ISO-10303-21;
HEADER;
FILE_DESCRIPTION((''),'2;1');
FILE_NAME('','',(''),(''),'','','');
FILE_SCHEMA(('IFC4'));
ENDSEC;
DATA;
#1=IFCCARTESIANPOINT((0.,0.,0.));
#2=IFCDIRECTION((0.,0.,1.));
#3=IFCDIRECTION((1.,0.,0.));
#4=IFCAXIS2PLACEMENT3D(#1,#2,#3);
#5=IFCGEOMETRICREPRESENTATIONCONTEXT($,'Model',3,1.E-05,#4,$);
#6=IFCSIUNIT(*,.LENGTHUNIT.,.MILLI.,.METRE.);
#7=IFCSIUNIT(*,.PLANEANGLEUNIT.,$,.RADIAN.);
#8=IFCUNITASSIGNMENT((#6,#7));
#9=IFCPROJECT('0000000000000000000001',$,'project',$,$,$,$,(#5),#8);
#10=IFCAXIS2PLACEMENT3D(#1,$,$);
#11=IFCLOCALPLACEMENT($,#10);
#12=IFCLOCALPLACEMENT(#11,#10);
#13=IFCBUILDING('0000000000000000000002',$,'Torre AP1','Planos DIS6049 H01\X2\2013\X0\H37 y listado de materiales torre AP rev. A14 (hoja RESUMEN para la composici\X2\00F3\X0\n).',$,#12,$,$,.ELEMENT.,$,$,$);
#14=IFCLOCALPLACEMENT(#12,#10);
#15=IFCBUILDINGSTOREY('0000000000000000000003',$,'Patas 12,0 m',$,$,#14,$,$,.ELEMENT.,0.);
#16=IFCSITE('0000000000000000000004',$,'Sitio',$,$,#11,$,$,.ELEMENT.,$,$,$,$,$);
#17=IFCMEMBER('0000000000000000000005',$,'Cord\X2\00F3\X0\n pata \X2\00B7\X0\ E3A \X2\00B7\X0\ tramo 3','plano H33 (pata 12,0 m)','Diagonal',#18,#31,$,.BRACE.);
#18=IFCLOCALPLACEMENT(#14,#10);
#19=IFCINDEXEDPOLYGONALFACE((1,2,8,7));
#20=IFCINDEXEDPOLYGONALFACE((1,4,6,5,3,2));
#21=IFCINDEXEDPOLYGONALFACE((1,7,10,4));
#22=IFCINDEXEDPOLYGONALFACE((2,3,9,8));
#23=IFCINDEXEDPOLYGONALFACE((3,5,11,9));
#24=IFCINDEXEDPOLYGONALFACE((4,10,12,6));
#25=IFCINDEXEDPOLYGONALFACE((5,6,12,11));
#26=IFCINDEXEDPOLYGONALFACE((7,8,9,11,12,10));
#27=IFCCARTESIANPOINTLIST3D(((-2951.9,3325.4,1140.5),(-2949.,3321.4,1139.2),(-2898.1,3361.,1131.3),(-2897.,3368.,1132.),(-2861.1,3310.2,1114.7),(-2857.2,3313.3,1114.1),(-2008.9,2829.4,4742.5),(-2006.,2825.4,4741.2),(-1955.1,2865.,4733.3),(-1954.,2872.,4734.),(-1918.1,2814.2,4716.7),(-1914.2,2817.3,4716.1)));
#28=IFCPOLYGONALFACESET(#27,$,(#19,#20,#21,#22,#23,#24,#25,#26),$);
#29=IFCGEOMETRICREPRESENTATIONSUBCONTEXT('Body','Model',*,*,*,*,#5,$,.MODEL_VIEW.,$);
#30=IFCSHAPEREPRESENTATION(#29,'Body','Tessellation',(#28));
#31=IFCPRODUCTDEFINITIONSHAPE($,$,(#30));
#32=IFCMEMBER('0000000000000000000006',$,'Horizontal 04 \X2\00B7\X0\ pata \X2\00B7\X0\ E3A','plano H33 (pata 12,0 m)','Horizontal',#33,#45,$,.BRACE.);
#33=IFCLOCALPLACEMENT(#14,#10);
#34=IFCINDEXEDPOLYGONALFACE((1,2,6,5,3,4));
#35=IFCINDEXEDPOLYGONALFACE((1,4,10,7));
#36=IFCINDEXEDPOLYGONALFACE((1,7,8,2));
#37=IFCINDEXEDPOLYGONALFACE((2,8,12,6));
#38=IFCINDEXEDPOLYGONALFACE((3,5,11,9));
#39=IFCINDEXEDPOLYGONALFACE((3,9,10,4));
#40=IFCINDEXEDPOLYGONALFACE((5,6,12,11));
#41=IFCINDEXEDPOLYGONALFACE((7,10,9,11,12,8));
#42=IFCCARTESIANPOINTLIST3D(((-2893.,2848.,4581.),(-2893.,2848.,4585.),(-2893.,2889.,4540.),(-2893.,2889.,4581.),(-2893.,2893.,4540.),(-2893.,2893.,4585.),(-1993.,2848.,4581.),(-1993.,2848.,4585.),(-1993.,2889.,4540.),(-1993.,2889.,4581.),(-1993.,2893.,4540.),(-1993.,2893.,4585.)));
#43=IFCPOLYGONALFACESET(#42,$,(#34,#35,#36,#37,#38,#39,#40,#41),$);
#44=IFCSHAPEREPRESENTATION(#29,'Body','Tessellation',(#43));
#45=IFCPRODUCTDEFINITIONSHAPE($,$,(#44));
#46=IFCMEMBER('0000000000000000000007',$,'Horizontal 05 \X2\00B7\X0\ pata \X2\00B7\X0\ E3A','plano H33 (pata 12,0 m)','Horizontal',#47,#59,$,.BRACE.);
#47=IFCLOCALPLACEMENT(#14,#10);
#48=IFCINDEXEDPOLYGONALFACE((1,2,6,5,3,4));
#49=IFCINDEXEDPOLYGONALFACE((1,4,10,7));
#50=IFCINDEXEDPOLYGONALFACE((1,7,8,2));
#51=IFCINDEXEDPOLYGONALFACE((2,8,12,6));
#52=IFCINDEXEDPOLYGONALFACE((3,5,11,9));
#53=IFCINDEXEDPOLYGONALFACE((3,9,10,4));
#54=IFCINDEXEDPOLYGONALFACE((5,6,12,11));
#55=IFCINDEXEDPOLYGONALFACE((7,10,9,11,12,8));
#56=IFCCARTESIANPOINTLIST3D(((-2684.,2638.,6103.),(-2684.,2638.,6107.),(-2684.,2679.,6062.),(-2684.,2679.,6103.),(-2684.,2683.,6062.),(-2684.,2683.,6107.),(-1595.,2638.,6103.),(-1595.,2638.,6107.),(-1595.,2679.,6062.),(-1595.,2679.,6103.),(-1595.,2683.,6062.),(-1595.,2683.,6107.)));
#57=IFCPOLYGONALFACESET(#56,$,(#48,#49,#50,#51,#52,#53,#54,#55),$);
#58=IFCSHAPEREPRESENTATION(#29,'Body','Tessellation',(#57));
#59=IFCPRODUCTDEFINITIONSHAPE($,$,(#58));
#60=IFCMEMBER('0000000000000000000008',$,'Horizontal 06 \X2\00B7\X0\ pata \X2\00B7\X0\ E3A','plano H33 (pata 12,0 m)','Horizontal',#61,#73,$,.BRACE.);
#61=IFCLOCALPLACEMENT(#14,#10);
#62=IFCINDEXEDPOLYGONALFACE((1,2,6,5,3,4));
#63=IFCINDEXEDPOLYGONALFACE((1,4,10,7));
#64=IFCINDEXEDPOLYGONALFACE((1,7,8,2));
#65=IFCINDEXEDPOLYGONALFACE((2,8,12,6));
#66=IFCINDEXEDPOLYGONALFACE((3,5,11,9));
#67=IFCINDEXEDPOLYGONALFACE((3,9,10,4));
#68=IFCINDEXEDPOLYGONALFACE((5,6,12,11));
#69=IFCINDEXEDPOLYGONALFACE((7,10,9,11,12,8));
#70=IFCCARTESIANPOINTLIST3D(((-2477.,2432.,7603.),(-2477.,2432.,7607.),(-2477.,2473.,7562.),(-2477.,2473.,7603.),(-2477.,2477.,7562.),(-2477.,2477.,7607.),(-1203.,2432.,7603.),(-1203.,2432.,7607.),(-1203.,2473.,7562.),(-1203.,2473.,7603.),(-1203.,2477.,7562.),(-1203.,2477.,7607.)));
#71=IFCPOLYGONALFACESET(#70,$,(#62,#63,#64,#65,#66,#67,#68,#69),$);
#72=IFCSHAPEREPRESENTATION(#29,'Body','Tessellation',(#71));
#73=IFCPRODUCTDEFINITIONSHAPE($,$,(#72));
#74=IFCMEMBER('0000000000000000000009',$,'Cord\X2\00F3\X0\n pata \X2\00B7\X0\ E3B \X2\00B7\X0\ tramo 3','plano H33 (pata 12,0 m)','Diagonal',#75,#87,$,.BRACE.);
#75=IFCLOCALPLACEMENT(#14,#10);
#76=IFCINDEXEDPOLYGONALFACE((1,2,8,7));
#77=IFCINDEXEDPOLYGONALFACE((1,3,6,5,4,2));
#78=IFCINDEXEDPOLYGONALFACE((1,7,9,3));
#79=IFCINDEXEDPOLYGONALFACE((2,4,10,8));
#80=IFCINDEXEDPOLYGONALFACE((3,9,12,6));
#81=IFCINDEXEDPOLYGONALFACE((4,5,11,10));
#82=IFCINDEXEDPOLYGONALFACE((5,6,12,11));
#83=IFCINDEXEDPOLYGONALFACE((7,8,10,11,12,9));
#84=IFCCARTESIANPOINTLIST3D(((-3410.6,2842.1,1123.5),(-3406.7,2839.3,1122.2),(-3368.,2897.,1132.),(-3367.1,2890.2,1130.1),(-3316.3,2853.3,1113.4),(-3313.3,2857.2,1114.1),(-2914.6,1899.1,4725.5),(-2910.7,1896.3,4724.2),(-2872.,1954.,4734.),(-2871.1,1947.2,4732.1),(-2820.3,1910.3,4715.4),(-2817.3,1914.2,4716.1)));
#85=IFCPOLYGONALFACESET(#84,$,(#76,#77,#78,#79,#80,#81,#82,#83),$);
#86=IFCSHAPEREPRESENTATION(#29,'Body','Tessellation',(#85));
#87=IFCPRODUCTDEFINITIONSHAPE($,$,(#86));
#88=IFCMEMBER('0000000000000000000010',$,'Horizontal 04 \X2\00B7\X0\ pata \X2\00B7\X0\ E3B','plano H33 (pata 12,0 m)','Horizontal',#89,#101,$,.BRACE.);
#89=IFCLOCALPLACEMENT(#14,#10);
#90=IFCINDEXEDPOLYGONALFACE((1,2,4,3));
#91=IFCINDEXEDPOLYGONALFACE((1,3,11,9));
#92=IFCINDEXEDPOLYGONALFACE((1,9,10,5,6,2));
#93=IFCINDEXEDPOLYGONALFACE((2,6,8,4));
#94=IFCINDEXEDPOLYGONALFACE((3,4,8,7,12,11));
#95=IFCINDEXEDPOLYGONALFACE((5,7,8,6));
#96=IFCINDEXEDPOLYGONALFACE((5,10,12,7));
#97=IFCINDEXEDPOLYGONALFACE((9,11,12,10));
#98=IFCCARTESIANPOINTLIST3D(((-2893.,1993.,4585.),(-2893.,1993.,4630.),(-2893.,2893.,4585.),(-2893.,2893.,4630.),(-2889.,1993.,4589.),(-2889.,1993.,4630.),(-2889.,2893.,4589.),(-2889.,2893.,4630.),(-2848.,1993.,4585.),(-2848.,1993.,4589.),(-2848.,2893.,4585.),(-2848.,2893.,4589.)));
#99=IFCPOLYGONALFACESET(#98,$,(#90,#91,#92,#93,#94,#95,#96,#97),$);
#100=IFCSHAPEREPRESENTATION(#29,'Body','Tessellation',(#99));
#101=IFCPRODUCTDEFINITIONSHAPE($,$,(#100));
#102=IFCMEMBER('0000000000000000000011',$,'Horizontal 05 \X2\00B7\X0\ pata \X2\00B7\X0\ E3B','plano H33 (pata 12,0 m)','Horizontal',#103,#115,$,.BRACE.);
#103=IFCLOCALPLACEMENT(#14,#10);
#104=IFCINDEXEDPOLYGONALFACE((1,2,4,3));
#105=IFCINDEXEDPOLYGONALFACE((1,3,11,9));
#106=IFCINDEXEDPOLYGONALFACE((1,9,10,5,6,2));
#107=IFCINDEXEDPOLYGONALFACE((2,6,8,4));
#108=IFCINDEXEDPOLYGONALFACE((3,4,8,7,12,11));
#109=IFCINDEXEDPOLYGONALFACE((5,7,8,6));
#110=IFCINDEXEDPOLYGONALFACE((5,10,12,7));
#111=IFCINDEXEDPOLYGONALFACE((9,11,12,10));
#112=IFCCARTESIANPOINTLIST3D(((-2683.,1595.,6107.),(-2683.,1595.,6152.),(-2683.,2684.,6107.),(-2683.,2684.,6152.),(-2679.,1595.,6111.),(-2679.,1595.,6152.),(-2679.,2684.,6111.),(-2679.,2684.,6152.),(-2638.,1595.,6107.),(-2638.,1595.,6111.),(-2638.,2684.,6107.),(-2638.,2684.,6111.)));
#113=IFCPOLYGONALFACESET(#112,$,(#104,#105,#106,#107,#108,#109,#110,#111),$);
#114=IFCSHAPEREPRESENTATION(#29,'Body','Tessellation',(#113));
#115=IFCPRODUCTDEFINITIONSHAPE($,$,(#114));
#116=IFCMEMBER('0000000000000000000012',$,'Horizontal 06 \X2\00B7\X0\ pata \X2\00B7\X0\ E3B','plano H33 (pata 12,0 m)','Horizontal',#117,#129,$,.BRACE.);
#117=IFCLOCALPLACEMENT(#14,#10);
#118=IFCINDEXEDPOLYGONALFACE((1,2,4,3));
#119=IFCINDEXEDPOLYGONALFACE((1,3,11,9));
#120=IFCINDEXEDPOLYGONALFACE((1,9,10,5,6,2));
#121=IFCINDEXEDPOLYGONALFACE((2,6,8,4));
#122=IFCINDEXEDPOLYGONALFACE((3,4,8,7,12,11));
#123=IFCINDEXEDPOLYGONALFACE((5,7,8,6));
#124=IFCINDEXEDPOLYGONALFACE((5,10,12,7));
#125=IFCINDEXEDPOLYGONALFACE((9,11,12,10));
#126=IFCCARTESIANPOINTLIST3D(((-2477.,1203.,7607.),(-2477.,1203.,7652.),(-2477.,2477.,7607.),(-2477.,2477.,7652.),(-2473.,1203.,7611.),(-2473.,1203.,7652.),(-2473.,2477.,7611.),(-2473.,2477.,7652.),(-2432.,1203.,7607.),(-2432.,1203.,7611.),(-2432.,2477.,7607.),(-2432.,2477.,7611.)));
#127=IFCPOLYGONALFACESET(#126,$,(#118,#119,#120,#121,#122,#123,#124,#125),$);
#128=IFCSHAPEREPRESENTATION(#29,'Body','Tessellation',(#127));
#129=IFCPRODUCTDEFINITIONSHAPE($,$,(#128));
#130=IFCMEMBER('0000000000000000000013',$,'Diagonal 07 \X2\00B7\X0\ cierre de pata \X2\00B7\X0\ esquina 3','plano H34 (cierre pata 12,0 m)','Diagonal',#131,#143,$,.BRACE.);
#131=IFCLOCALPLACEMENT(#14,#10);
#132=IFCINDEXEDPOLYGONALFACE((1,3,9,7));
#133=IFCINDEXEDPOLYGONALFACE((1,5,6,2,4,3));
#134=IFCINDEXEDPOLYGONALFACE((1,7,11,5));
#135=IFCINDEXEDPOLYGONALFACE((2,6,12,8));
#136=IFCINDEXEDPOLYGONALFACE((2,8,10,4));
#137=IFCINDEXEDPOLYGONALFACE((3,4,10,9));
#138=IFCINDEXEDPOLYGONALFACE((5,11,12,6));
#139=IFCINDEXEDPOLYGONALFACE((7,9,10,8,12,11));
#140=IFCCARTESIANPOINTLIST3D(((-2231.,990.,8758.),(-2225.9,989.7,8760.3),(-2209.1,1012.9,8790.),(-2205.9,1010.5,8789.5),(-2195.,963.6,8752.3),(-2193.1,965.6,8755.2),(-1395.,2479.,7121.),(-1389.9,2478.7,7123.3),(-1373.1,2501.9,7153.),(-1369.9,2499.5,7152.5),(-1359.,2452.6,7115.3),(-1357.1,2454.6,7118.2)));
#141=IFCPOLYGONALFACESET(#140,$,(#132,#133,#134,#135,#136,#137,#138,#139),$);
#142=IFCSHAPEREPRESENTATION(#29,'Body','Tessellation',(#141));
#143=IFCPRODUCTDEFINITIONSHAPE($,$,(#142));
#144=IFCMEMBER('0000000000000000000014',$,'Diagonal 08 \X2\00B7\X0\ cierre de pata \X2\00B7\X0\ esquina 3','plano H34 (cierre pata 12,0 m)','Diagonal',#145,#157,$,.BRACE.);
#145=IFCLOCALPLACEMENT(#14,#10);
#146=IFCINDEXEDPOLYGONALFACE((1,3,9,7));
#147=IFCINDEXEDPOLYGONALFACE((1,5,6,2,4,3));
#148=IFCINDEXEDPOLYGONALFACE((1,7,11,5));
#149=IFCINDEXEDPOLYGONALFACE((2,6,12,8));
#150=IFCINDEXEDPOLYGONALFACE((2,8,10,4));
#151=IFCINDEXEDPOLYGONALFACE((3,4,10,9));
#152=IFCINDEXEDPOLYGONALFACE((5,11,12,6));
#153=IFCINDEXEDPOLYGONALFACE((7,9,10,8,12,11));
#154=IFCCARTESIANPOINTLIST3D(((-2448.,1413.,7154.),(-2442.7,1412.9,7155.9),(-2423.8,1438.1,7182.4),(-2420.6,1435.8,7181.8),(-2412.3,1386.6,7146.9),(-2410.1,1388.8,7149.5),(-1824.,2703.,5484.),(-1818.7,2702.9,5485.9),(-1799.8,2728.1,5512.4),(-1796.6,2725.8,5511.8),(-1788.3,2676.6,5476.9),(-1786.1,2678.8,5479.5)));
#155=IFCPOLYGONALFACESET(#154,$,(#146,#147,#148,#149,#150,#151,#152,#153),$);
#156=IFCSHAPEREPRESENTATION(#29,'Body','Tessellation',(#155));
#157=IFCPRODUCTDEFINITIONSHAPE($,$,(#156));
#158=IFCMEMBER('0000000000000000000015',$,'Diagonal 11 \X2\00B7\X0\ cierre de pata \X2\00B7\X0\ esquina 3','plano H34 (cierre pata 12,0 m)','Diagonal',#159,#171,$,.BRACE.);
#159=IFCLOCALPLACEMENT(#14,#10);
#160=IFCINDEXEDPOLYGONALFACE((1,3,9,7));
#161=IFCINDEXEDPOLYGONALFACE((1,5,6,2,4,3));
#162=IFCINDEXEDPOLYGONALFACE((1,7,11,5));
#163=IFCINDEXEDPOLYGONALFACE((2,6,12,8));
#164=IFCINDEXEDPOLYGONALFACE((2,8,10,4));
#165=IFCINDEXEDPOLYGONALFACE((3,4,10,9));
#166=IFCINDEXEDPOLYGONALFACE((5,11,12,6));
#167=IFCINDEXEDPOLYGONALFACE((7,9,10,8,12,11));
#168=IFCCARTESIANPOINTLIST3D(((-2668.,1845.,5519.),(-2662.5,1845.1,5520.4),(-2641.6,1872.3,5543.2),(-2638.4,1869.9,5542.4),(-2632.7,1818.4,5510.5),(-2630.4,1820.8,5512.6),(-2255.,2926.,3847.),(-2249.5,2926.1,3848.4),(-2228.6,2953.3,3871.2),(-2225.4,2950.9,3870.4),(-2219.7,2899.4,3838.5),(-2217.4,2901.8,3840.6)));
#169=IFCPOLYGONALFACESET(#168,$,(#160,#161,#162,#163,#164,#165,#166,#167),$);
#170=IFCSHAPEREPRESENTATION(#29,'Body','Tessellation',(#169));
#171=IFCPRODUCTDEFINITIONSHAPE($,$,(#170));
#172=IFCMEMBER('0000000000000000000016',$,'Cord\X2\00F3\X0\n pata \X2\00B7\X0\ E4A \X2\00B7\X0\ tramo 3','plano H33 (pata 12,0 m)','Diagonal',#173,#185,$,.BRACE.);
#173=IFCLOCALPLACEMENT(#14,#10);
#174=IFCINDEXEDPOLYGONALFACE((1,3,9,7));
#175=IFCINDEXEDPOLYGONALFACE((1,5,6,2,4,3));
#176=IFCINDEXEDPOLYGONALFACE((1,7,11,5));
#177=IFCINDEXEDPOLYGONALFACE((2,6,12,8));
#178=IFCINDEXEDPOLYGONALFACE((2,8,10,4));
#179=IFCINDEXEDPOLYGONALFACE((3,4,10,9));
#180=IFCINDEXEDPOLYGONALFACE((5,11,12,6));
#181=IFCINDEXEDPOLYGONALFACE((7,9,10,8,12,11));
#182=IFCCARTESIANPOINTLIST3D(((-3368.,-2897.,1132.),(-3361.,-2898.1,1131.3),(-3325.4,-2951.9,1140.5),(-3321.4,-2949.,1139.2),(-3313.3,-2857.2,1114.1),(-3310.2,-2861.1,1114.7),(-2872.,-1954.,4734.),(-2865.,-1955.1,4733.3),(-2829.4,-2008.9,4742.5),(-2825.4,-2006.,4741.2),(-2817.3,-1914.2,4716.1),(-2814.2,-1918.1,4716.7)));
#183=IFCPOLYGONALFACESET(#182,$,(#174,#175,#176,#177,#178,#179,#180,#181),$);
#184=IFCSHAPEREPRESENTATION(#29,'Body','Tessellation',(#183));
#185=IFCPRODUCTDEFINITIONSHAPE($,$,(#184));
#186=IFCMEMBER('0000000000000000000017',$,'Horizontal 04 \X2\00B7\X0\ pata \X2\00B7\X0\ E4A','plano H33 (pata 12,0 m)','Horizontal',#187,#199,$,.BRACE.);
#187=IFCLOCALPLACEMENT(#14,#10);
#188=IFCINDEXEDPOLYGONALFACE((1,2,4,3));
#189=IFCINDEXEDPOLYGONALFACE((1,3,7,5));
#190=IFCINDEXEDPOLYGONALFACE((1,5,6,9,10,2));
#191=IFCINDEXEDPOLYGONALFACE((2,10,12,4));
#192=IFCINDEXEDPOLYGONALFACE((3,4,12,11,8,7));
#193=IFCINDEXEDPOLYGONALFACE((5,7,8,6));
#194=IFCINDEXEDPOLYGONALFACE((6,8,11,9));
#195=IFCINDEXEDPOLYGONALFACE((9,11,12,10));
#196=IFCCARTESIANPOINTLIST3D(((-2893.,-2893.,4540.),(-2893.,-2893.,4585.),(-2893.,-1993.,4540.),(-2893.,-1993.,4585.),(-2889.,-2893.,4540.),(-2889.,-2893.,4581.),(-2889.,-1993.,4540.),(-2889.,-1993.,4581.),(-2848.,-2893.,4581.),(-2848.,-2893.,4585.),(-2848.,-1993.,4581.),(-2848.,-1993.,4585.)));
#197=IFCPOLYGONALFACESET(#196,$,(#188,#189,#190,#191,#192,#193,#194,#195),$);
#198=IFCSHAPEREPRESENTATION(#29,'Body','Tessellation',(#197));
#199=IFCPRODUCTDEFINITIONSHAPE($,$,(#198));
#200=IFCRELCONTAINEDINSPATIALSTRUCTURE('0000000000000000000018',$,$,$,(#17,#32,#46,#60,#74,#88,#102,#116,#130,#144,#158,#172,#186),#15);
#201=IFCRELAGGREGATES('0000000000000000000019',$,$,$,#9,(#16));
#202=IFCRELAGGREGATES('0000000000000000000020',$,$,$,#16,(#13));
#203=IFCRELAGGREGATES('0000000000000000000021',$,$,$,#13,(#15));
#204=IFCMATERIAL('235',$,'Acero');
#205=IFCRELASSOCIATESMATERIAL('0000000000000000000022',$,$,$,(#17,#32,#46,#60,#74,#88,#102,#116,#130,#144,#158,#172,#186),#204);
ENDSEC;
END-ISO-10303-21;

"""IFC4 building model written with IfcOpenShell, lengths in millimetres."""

from ifc_helpers import new_model, si_unit, frame, frame_2d, origin, origin_with_axes, place, context, subcontext, project, spatial, l_section, extrude, material, element, save


model = new_model("IFC4")

# Units and contexts
model_context = context("Model", 3, precision=1e-05, world=origin_with_axes())
body_context = subcontext(model_context, "Body", "Model", "MODEL_VIEW")
ifc_project = project(units=[si_unit("LENGTHUNIT", "METRE", prefix="MILLI"), si_unit("PLANEANGLEUNIT", "RADIAN")], contexts=[model_context])

# Site, building, storey
site_placement = place(None, origin())
site = spatial("IfcSite", under=ifc_project, at=site_placement, Name="Sitio", CompositionType="ELEMENT")
building_placement = place(site_placement, origin())
building = spatial("IfcBuilding", under=site, at=building_placement, Name="Torre AP1", Description="Planos DIS6049 H01–H37 y listado de materiales torre AP rev. A14 (hoja RESUMEN para la composición).", CompositionType="ELEMENT")
storey_placement = place(building_placement, origin())
storey = spatial("IfcBuildingStorey", under=building, at=storey_placement, Name="Patas 12,0 m", CompositionType="ELEMENT", Elevation=0.0)

# Members
ifc_material = material(Name="235", Category="Acero")
member_1_placement = place(storey_placement, frame((-1954.0, 2872.0, 4734.0), z_axis=(-0.251046, 0.132045, -0.958926), x_axis=(0.56819, -0.781925, -0.256424)))
element("IfcMember", 1, at=member_1_placement, inside=storey, material=ifc_material, Name="Cordón pata · E3A · tramo 3", Description="plano H33 (pata 12,0 m)", ObjectType="Diagonal", PredefinedType="BRACE", context=body_context, shape_type="SweptSolid", body=[
    extrude(l_section(Depth=70.0, Width=70.0, Thickness=5.0, at=frame_2d((35.0, 35.0))), None, (0.0, 0.0, 1.0), 3756.3),
])
member_2_placement = place(storey_placement, frame((-2893.0, 2893.0, 4585.0), z_axis=(1.0, 0.0, 0.0), x_axis=(0.0, -1.0, 0.0)))
element("IfcMember", 2, at=member_2_placement, inside=storey, material=ifc_material, Name="Horizontal 04 · pata · E3A", Description="plano H33 (pata 12,0 m)", ObjectType="Horizontal", PredefinedType="BRACE", context=body_context, shape_type="SweptSolid", body=[
    extrude(l_section(Depth=45.0, Width=45.0, Thickness=4.0, at=frame_2d((22.5, 22.5))), None, (0.0, 0.0, 1.0), 900.0),
])
member_3_placement = place(storey_placement, frame((-2684.0, 2683.0, 6107.0), z_axis=(1.0, 0.0, 0.0), x_axis=(0.0, -1.0, 0.0)))
element("IfcMember", 3, at=member_3_placement, inside=storey, material=ifc_material, Name="Horizontal 05 · pata · E3A", Description="plano H33 (pata 12,0 m)", ObjectType="Horizontal", PredefinedType="BRACE", context=body_context, shape_type="SweptSolid", body=[
    extrude(l_section(Depth=45.0, Width=45.0, Thickness=4.0, at=frame_2d((22.5, 22.5))), None, (0.0, 0.0, 1.0), 1089.0),
])
member_4_placement = place(storey_placement, frame((-2477.0, 2477.0, 7607.0), z_axis=(1.0, 0.0, 0.0), x_axis=(0.0, -1.0, 0.0)))
element("IfcMember", 4, at=member_4_placement, inside=storey, material=ifc_material, Name="Horizontal 06 · pata · E3A", Description="plano H33 (pata 12,0 m)", ObjectType="Horizontal", PredefinedType="BRACE", context=body_context, shape_type="SweptSolid", body=[
    extrude(l_section(Depth=45.0, Width=45.0, Thickness=4.0, at=frame_2d((22.5, 22.5))), None, (0.0, 0.0, 1.0), 1274.0),
])
member_5_placement = place(storey_placement, frame((-2872.0, 1954.0, 4734.0), z_axis=(-0.132045, 0.251046, -0.958926), x_axis=(0.781925, -0.56819, -0.256424)))
element("IfcMember", 5, at=member_5_placement, inside=storey, material=ifc_material, Name="Cordón pata · E3B · tramo 3", Description="plano H33 (pata 12,0 m)", ObjectType="Diagonal", PredefinedType="BRACE", context=body_context, shape_type="SweptSolid", body=[
    extrude(l_section(Depth=70.0, Width=70.0, Thickness=5.0, at=frame_2d((35.0, 35.0))), None, (0.0, 0.0, 1.0), 3756.3),
])
member_6_placement = place(storey_placement, frame((-2893.0, 2893.0, 4585.0), z_axis=(0.0, -1.0, 0.0), x_axis=(1.0, 0.0, 0.0)))
element("IfcMember", 6, at=member_6_placement, inside=storey, material=ifc_material, Name="Horizontal 04 · pata · E3B", Description="plano H33 (pata 12,0 m)", ObjectType="Horizontal", PredefinedType="BRACE", context=body_context, shape_type="SweptSolid", body=[
    extrude(l_section(Depth=45.0, Width=45.0, Thickness=4.0, at=frame_2d((22.5, 22.5))), None, (0.0, 0.0, 1.0), 900.0),
])
member_7_placement = place(storey_placement, frame((-2683.0, 2684.0, 6107.0), z_axis=(0.0, -1.0, 0.0), x_axis=(1.0, 0.0, 0.0)))
element("IfcMember", 7, at=member_7_placement, inside=storey, material=ifc_material, Name="Horizontal 05 · pata · E3B", Description="plano H33 (pata 12,0 m)", ObjectType="Horizontal", PredefinedType="BRACE", context=body_context, shape_type="SweptSolid", body=[
    extrude(l_section(Depth=45.0, Width=45.0, Thickness=4.0, at=frame_2d((22.5, 22.5))), None, (0.0, 0.0, 1.0), 1089.0),
])
member_8_placement = place(storey_placement, frame((-2477.0, 2477.0, 7607.0), z_axis=(0.0, -1.0, 0.0), x_axis=(1.0, 0.0, 0.0)))
element("IfcMember", 8, at=member_8_placement, inside=storey, material=ifc_material, Name="Horizontal 06 · pata · E3B", Description="plano H33 (pata 12,0 m)", ObjectType="Horizontal", PredefinedType="BRACE", context=body_context, shape_type="SweptSolid", body=[
    extrude(l_section(Depth=45.0, Width=45.0, Thickness=4.0, at=frame_2d((22.5, 22.5))), None, (0.0, 0.0, 1.0), 1274.0),
])
member_9_placement = place(storey_placement, frame((-1395.0, 2479.0, 7121.0), z_axis=(-0.353407, -0.629454, 0.692019), x_axis=(0.799129, -0.587707, -0.126466)))
element("IfcMember", 9, at=member_9_placement, inside=storey, material=ifc_material, Name="Diagonal 07 · cierre de pata · esquina 3", Description="plano H34 (cierre pata 12,0 m)", ObjectType="Diagonal", PredefinedType="BRACE", context=body_context, shape_type="SweptSolid", body=[
    extrude(l_section(Depth=45.0, Width=45.0, Thickness=4.0, at=frame_2d((22.5, 22.5))), None, (0.0, 0.0, 1.0), 2365.5),
])
member_10_placement = place(storey_placement, frame((-1824.0, 2703.0, 5484.0), z_axis=(-0.283567, -0.58622, 0.758905), x_axis=(0.794021, -0.587278, -0.156957)))
element("IfcMember", 10, at=member_10_placement, inside=storey, material=ifc_material, Name="Diagonal 08 · cierre de pata · esquina 3", Description="plano H34 (cierre pata 12,0 m)", ObjectType="Diagonal", PredefinedType="BRACE", context=body_context, shape_type="SweptSolid", body=[
    extrude(l_section(Depth=45.0, Width=45.0, Thickness=4.0, at=frame_2d((22.5, 22.5))), None, (0.0, 0.0, 1.0), 2200.5),
])
member_11_placement = place(storey_placement, frame((-2255.0, 2926.0, 3847.0), z_axis=(-0.203108, -0.531622, 0.822268), x_axis=(0.783559, -0.591842, -0.189098)))
element("IfcMember", 11, at=member_11_placement, inside=storey, material=ifc_material, Name="Diagonal 11 · cierre de pata · esquina 3", Description="plano H34 (cierre pata 12,0 m)", ObjectType="Diagonal", PredefinedType="BRACE", context=body_context, shape_type="SweptSolid", body=[
    extrude(l_section(Depth=45.0, Width=45.0, Thickness=4.0, at=frame_2d((22.5, 22.5))), None, (0.0, 0.0, 1.0), 2033.4),
])
member_12_placement = place(storey_placement, frame((-2872.0, -1954.0, 4734.0), z_axis=(-0.132045, -0.251046, -0.958926), x_axis=(0.781925, 0.56819, -0.256424)))
element("IfcMember", 12, at=member_12_placement, inside=storey, material=ifc_material, Name="Cordón pata · E4A · tramo 3", Description="plano H33 (pata 12,0 m)", ObjectType="Diagonal", PredefinedType="BRACE", context=body_context, shape_type="SweptSolid", body=[
    extrude(l_section(Depth=70.0, Width=70.0, Thickness=5.0, at=frame_2d((35.0, 35.0))), None, (0.0, 0.0, 1.0), 3756.3),
])
member_13_placement = place(storey_placement, frame((-2893.0, -2893.0, 4585.0), z_axis=(0.0, 1.0, 0.0), x_axis=(1.0, 0.0, 0.0)))
element("IfcMember", 13, at=member_13_placement, inside=storey, material=ifc_material, Name="Horizontal 04 · pata · E4A", Description="plano H33 (pata 12,0 m)", ObjectType="Horizontal", PredefinedType="BRACE", context=body_context, shape_type="SweptSolid", body=[
    extrude(l_section(Depth=45.0, Width=45.0, Thickness=4.0, at=frame_2d((22.5, 22.5))), None, (0.0, 0.0, 1.0), 900.0),
])

save(model, "model.ifc")
